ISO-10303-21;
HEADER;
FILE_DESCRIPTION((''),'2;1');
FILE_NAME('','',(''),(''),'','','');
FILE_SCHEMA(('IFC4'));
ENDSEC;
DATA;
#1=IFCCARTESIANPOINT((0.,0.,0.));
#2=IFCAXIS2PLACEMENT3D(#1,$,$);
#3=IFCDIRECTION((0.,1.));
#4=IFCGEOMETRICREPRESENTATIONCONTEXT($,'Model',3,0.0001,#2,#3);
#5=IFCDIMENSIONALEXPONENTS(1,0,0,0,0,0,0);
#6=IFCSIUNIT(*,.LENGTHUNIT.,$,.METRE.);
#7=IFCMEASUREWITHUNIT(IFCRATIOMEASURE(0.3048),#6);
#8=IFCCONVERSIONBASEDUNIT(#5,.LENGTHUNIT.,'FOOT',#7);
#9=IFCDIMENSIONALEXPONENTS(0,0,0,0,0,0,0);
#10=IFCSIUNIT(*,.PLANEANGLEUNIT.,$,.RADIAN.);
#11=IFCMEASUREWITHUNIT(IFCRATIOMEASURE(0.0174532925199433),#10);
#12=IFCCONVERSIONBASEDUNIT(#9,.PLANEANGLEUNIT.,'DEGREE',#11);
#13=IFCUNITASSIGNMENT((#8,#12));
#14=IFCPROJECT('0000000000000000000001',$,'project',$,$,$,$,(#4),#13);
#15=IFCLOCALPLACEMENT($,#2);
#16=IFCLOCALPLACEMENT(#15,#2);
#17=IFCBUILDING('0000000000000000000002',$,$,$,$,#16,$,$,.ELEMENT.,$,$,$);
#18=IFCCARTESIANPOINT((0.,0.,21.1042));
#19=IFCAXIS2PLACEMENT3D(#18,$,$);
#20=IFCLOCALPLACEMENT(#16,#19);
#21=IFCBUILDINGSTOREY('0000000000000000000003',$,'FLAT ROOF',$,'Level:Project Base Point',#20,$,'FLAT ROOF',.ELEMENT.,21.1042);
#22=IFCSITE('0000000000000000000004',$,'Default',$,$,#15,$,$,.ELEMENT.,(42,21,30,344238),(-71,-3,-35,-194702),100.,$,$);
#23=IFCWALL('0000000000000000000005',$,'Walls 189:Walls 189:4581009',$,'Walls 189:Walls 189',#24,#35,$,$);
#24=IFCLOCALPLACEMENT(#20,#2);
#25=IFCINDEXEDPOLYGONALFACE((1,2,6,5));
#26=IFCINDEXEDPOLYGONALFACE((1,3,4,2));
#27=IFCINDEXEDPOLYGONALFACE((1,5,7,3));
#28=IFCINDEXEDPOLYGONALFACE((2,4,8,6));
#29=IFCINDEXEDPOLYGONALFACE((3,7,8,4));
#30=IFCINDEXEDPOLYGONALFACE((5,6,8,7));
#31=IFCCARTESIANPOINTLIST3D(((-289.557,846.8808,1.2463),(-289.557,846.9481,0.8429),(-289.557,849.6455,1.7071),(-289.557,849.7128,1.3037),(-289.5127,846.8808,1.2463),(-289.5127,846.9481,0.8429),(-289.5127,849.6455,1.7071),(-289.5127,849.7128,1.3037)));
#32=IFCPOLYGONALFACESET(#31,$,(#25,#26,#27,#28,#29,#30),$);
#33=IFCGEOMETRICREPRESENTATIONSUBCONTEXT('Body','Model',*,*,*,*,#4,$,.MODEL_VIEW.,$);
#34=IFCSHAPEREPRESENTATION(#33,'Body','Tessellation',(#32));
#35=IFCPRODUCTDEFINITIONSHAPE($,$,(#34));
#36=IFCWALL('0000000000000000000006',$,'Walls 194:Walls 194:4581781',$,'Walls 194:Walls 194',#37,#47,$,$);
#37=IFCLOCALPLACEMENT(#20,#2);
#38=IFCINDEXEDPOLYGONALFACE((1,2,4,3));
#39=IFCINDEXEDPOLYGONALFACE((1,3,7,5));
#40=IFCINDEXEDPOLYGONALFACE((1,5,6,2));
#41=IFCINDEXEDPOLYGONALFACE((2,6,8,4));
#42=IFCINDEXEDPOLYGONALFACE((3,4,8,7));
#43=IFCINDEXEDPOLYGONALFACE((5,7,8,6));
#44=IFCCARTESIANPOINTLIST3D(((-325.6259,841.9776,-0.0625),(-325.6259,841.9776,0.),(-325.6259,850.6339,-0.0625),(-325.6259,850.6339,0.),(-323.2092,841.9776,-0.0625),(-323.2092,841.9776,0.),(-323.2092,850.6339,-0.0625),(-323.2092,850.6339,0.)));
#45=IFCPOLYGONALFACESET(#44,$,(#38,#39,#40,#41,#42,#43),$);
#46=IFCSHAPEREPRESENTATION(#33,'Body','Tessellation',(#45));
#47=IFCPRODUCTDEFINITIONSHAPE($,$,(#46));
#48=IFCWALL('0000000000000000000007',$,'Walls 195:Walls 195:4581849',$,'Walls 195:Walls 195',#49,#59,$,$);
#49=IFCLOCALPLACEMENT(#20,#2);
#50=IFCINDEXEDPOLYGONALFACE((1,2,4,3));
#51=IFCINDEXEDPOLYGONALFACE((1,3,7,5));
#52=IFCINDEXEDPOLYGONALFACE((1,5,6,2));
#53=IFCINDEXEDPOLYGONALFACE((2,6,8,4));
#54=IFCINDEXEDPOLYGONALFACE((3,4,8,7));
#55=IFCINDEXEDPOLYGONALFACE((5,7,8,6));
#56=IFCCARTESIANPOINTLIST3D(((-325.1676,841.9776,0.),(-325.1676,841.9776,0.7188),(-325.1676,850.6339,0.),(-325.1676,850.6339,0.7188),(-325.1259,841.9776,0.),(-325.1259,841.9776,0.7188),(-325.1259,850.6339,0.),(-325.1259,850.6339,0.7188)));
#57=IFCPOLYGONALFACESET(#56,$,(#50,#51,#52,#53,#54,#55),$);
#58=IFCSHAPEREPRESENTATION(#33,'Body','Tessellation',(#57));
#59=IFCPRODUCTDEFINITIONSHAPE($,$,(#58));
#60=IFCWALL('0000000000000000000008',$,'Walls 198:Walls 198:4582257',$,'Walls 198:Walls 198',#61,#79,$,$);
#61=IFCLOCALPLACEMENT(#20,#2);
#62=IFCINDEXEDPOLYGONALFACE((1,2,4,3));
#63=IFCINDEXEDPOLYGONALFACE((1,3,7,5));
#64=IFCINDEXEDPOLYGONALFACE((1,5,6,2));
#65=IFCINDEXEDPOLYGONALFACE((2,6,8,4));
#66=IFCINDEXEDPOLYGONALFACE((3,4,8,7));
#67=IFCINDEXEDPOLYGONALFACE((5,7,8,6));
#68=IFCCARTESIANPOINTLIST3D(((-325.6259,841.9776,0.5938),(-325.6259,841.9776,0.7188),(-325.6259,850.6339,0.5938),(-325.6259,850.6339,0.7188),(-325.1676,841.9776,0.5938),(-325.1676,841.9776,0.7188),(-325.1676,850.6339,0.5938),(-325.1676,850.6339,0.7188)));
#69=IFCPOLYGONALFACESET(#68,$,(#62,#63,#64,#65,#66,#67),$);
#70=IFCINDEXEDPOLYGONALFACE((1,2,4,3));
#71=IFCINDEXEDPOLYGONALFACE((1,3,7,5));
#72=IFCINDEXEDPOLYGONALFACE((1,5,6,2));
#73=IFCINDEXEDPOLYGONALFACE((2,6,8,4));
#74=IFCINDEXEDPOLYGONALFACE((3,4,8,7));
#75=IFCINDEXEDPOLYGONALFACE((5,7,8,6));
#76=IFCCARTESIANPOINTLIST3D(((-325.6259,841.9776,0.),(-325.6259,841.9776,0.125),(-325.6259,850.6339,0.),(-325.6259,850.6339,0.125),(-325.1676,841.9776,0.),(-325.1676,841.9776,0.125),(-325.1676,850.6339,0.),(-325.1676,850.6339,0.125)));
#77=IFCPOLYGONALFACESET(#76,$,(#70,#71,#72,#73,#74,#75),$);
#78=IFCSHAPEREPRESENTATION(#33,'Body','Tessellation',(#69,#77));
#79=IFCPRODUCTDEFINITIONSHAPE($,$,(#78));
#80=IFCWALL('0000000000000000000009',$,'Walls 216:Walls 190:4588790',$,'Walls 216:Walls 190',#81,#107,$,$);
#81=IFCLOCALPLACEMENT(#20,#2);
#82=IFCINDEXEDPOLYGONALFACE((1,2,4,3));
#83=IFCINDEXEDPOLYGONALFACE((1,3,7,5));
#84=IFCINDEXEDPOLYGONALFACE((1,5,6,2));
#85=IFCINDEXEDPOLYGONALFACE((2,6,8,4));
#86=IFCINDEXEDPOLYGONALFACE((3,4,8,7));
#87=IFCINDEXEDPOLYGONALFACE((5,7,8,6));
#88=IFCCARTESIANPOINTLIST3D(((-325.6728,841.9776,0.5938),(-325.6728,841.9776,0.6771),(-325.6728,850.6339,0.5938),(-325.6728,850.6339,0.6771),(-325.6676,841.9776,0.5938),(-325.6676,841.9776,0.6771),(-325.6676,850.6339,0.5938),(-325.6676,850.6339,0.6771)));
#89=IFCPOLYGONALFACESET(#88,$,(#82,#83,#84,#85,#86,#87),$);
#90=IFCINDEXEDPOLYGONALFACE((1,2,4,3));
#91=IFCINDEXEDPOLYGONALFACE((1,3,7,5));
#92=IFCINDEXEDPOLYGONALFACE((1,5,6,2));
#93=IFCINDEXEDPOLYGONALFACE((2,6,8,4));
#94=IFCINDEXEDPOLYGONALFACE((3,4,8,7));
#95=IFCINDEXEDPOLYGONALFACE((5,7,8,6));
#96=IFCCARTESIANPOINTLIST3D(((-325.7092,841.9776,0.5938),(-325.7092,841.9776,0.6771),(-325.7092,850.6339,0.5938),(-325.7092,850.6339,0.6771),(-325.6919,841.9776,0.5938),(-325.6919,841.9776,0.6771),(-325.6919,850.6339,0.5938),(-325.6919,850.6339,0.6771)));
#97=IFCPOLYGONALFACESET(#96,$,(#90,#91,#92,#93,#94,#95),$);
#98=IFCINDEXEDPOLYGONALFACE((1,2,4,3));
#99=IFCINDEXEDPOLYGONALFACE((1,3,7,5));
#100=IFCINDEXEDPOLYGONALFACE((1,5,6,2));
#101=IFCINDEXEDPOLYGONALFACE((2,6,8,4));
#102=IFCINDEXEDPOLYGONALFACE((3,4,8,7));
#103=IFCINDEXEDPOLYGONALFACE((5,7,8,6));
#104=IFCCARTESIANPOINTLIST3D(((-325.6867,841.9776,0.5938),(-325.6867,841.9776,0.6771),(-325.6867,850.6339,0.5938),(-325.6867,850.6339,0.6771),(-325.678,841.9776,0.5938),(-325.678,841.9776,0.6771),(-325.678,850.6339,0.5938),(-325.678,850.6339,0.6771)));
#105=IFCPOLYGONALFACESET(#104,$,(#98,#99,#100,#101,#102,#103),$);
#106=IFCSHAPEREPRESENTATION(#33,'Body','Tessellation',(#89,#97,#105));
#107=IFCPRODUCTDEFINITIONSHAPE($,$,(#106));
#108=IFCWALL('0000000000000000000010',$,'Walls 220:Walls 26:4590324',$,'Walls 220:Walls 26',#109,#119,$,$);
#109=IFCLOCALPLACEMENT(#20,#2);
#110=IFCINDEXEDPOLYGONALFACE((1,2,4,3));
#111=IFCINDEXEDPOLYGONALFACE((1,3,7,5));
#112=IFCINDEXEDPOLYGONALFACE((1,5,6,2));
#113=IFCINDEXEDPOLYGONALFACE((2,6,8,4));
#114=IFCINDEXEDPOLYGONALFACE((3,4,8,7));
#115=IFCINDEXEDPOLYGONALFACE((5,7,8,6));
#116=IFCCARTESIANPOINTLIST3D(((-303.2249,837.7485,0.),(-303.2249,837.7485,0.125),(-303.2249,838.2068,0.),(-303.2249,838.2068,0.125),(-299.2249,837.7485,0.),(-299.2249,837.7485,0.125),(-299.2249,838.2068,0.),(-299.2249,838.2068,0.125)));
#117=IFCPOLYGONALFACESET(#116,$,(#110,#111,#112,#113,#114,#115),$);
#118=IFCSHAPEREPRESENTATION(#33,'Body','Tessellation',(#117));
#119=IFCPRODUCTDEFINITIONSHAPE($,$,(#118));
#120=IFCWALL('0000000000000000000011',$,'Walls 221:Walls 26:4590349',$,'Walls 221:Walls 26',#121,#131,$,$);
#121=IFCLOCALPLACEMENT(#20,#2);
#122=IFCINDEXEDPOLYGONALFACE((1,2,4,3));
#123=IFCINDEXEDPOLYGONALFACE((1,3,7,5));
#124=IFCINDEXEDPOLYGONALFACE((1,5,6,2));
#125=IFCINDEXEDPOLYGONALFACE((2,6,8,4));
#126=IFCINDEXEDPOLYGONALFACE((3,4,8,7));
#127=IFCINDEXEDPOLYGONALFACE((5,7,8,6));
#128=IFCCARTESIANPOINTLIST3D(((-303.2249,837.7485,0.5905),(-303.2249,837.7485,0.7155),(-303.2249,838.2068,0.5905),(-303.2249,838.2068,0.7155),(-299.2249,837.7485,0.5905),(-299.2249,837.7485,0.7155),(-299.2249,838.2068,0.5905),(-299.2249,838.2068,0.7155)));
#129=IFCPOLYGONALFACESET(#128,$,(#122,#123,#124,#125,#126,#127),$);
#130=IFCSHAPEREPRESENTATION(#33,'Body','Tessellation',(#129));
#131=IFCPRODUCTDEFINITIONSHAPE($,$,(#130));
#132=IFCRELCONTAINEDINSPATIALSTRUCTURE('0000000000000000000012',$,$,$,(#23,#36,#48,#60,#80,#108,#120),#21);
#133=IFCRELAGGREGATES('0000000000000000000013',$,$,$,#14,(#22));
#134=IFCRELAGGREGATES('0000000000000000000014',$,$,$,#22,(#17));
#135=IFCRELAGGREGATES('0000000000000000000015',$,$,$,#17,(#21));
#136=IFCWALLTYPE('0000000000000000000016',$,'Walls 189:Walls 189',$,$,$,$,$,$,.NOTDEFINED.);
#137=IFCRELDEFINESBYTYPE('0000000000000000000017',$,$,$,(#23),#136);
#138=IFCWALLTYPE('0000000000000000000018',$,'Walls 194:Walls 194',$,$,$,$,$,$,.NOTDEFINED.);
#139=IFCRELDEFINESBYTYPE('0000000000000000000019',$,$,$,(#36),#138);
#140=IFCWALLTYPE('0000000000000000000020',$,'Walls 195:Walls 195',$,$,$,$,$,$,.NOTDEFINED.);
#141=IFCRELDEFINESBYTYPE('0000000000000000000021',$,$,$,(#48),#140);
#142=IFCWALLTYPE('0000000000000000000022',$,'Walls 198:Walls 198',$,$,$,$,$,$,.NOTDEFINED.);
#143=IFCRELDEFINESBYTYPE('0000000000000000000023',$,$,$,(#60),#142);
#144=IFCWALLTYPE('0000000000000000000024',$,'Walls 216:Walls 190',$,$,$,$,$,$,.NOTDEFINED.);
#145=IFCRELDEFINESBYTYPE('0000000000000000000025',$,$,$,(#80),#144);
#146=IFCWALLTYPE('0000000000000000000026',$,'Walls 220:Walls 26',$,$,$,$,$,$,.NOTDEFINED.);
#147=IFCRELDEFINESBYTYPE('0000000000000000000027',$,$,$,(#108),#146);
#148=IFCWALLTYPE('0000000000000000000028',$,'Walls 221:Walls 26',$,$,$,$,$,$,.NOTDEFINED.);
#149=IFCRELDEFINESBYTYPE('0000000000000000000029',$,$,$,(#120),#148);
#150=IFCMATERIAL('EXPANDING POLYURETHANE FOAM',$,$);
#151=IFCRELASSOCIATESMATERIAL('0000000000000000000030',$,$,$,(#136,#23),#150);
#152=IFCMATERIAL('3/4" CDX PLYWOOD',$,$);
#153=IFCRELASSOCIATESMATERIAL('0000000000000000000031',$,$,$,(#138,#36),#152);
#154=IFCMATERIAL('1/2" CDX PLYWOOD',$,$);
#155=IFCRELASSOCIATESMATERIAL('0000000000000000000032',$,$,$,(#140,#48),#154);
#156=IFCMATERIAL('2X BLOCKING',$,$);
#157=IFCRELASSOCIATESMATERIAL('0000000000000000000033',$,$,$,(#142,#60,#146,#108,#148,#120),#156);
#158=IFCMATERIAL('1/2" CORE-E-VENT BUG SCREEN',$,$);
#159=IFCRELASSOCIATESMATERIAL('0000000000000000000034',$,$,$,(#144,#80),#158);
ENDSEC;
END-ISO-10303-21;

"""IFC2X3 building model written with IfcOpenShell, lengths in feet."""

from ifc_helpers import new_model, entity, si_unit, converted_unit, direction, frame, frame_2d, origin, origin_2d_with_axis, place, context, subcontext, project, spatial, rectangle, extrude, material, type_object, element, save


model = new_model("IFC2X3")

# Units and contexts
model_context = context("Model", 3, precision=0.0001, world=origin(), true_north=direction((0.0, 1.0)))
body_context = subcontext(model_context, "Body", "Model", "MODEL_VIEW")
ifc_project = project(units=[converted_unit("LENGTHUNIT", "FOOT", entity("IfcRatioMeasure", 0.3048), si_unit("LENGTHUNIT", "METRE"), dimensions=[1, 0, 0, 0, 0, 0, 0]), converted_unit("PLANEANGLEUNIT", "DEGREE", entity("IfcRatioMeasure", 0.0174532925199433), si_unit("PLANEANGLEUNIT", "RADIAN"), dimensions=[0, 0, 0, 0, 0, 0, 0])], contexts=[model_context])

# Site, building, storey
site_placement = place(None, origin())
site = spatial("IfcSite", under=ifc_project, at=site_placement, Name="Default", CompositionType="ELEMENT", RefLatitude=(42, 21, 30, 344238), RefLongitude=(-71, -3, -35, -194702), RefElevation=100.0)
building_placement = place(site_placement, origin())
building = spatial("IfcBuilding", under=site, at=building_placement, CompositionType="ELEMENT")
storey_placement = place(building_placement, frame((0.0, 0.0, 21.1042)))
storey = spatial("IfcBuildingStorey", under=building, at=storey_placement, Name="FLAT ROOF", ObjectType="Level:Project Base Point", LongName="FLAT ROOF", CompositionType="ELEMENT", Elevation=21.1042)

# Walls
ifc_material_1 = material(Name="1/2\" CDX PLYWOOD")
ifc_material_2 = material(Name="3/4\" CDX PLYWOOD")
ifc_material_3 = material(Name="2X BLOCKING")
ifc_material_4 = material(Name="EXPANDING POLYURETHANE FOAM")
wall_type_1 = type_object("IfcWallType", Name="Walls 189:Walls 189", PredefinedType="NOTDEFINED", material=ifc_material_4)
wall_1_placement = place(storey_placement, frame((-289.557, 846.8808, 0.8429), z_axis=(0.0, 0.0, 1.0), x_axis=(0.0, 1.0, 0.0)))
element("IfcWall", 1, at=wall_1_placement, inside=storey, type_object=wall_type_1, material=ifc_material_4, Name="Walls 189:Walls 189:4581009", ObjectType="Walls 189:Walls 189", context=body_context, shape_type="SweptSolid", body=[
    extrude(rectangle(XDim=2.8028, YDim=0.0443, at=frame_2d((0.0, 0.0), x_axis=(1.0, 0.0))), frame((1.4496, -0.0222, 0.2304), z_axis=(-0.164399, 0.0, 0.986394), x_axis=(-0.986394, 0.0, -0.164399)), (0.0, 0.0, 1.0), 0.409),
])
wall_type_2 = type_object("IfcWallType", Name="Walls 194:Walls 194", PredefinedType="NOTDEFINED", material=ifc_material_2)
wall_2_placement = place(storey_placement, frame((-325.6259, 841.9776, -0.0625), z_axis=(0.0, 0.0, 1.0), x_axis=(0.0, 1.0, 0.0)))
element("IfcWall", 2, at=wall_2_placement, inside=storey, type_object=wall_type_2, material=ifc_material_2, Name="Walls 194:Walls 194:4581781", ObjectType="Walls 194:Walls 194", context=body_context, shape_type="SweptSolid", body=[
    extrude(rectangle(XDim=8.6563, YDim=2.4167, at=frame_2d((0.0, 0.0), x_axis=(1.0, 0.0))), frame((4.3281, -1.2083, 0.0), z_axis=(0.0, 0.0, 1.0), x_axis=(-1.0, 0.0, 0.0)), (0.0, 0.0, 1.0), 0.0625),
])
wall_type_3 = type_object("IfcWallType", Name="Walls 195:Walls 195", PredefinedType="NOTDEFINED", material=ifc_material_1)
wall_3_placement = place(storey_placement, frame((-325.1676, 841.9776, 0.0), z_axis=(0.0, 0.0, 1.0), x_axis=(0.0, 1.0, 0.0)))
element("IfcWall", 3, at=wall_3_placement, inside=storey, type_object=wall_type_3, material=ifc_material_1, Name="Walls 195:Walls 195:4581849", ObjectType="Walls 195:Walls 195", context=body_context, shape_type="SweptSolid", body=[
    extrude(rectangle(XDim=8.6563, YDim=0.0417, at=frame_2d((0.0, 0.0), x_axis=(1.0, 0.0))), frame((4.3281, -0.0208, 0.0), z_axis=(0.0, 0.0, 1.0), x_axis=(-1.0, 0.0, 0.0)), (0.0, 0.0, 1.0), 0.7188),
])
wall_type_4 = type_object("IfcWallType", Name="Walls 198:Walls 198", PredefinedType="NOTDEFINED", material=ifc_material_3)
wall_4_placement = place(storey_placement, frame((-325.6259, 841.9776, 0.0), z_axis=(0.0, 0.0, 1.0), x_axis=(0.0, 1.0, 0.0)))
element("IfcWall", 4, at=wall_4_placement, inside=storey, type_object=wall_type_4, material=ifc_material_3, Name="Walls 198:Walls 198:4582257", ObjectType="Walls 198:Walls 198", context=body_context, shape_type="SweptSolid", body=[
    extrude(rectangle(XDim=8.6563, YDim=0.4583, at=frame_2d((0.0, 0.0), x_axis=(1.0, 0.0))), frame((4.3281, -0.2292, 0.5938), z_axis=(0.0, 0.0, 1.0), x_axis=(-1.0, 0.0, 0.0)), (0.0, 0.0, 1.0), 0.125),
    extrude(rectangle(XDim=8.6563, YDim=0.4583, at=frame_2d((0.0, 0.0), x_axis=(1.0, 0.0))), frame((4.3281, -0.2292, 0.0), z_axis=(0.0, 0.0, 1.0), x_axis=(-1.0, 0.0, 0.0)), (0.0, 0.0, 1.0), 0.125),
])
ifc_material_5 = material(Name="1/2\" CORE-E-VENT BUG SCREEN")
wall_type_5 = type_object("IfcWallType", Name="Walls 216:Walls 190", PredefinedType="NOTDEFINED", material=ifc_material_5)
wall_5_placement = place(storey_placement, frame((-325.7092, 841.9776, 0.5938), z_axis=(0.0, 0.0, 1.0), x_axis=(0.0, 1.0, 0.0)))
element("IfcWall", 5, at=wall_5_placement, inside=storey, type_object=wall_type_5, material=ifc_material_5, Name="Walls 216:Walls 190:4588790", ObjectType="Walls 216:Walls 190", context=body_context, shape_type="SweptSolid", body=[
    extrude(rectangle(XDim=8.6563, YDim=0.0052, at=frame_2d((0.0, 0.0), x_axis=(1.0, 0.0))), frame((4.3281, -0.0391, 0.0), z_axis=(0.0, 0.0, 1.0), x_axis=(-1.0, 0.0, 0.0)), (0.0, 0.0, 1.0), 0.0833),
    extrude(rectangle(XDim=8.6563, YDim=0.0174, at=origin_2d_with_axis()), frame((4.3281, -0.0087, 0.0), z_axis=(0.0, 0.0, 1.0), x_axis=(-1.0, 0.0, 0.0)), (0.0, 0.0, 1.0), 0.0833),
    extrude(rectangle(XDim=8.6563, YDim=0.0087, at=frame_2d((0.0, 0.0), x_axis=(1.0, 0.0))), frame((4.3281, -0.0269, 0.0), z_axis=(0.0, 0.0, 1.0), x_axis=(-1.0, 0.0, 0.0)), (0.0, 0.0, 1.0), 0.0833),
])
wall_type_6 = type_object("IfcWallType", Name="Walls 220:Walls 26", PredefinedType="NOTDEFINED", material=ifc_material_3)
wall_6_placement = place(storey_placement, frame((-303.2249, 837.7485, 0.0)))
element("IfcWall", 6, at=wall_6_placement, inside=storey, type_object=wall_type_6, material=ifc_material_3, Name="Walls 220:Walls 26:4590324", ObjectType="Walls 220:Walls 26", context=body_context, shape_type="SweptSolid", body=[
    extrude(rectangle(XDim=4.0, YDim=0.4583, at=origin_2d_with_axis()), frame((2.0, 0.2292, 0.0), z_axis=(0.0, 0.0, 1.0), x_axis=(-1.0, 0.0, 0.0)), (0.0, 0.0, 1.0), 0.125),
])
wall_type_7 = type_object("IfcWallType", Name="Walls 221:Walls 26", PredefinedType="NOTDEFINED", material=ifc_material_3)
wall_7_placement = place(storey_placement, frame((-303.2249, 837.7485, 0.5905)))
element("IfcWall", 7, at=wall_7_placement, inside=storey, type_object=wall_type_7, material=ifc_material_3, Name="Walls 221:Walls 26:4590349", ObjectType="Walls 221:Walls 26", context=body_context, shape_type="SweptSolid", body=[
    extrude(rectangle(XDim=4.0, YDim=0.4583, at=origin_2d_with_axis()), frame((2.0, 0.2292, 0.0), z_axis=(0.0, 0.0, 1.0), x_axis=(-1.0, 0.0, 0.0)), (0.0, 0.0, 1.0), 0.125),
])

save(model, "model.ifc")
